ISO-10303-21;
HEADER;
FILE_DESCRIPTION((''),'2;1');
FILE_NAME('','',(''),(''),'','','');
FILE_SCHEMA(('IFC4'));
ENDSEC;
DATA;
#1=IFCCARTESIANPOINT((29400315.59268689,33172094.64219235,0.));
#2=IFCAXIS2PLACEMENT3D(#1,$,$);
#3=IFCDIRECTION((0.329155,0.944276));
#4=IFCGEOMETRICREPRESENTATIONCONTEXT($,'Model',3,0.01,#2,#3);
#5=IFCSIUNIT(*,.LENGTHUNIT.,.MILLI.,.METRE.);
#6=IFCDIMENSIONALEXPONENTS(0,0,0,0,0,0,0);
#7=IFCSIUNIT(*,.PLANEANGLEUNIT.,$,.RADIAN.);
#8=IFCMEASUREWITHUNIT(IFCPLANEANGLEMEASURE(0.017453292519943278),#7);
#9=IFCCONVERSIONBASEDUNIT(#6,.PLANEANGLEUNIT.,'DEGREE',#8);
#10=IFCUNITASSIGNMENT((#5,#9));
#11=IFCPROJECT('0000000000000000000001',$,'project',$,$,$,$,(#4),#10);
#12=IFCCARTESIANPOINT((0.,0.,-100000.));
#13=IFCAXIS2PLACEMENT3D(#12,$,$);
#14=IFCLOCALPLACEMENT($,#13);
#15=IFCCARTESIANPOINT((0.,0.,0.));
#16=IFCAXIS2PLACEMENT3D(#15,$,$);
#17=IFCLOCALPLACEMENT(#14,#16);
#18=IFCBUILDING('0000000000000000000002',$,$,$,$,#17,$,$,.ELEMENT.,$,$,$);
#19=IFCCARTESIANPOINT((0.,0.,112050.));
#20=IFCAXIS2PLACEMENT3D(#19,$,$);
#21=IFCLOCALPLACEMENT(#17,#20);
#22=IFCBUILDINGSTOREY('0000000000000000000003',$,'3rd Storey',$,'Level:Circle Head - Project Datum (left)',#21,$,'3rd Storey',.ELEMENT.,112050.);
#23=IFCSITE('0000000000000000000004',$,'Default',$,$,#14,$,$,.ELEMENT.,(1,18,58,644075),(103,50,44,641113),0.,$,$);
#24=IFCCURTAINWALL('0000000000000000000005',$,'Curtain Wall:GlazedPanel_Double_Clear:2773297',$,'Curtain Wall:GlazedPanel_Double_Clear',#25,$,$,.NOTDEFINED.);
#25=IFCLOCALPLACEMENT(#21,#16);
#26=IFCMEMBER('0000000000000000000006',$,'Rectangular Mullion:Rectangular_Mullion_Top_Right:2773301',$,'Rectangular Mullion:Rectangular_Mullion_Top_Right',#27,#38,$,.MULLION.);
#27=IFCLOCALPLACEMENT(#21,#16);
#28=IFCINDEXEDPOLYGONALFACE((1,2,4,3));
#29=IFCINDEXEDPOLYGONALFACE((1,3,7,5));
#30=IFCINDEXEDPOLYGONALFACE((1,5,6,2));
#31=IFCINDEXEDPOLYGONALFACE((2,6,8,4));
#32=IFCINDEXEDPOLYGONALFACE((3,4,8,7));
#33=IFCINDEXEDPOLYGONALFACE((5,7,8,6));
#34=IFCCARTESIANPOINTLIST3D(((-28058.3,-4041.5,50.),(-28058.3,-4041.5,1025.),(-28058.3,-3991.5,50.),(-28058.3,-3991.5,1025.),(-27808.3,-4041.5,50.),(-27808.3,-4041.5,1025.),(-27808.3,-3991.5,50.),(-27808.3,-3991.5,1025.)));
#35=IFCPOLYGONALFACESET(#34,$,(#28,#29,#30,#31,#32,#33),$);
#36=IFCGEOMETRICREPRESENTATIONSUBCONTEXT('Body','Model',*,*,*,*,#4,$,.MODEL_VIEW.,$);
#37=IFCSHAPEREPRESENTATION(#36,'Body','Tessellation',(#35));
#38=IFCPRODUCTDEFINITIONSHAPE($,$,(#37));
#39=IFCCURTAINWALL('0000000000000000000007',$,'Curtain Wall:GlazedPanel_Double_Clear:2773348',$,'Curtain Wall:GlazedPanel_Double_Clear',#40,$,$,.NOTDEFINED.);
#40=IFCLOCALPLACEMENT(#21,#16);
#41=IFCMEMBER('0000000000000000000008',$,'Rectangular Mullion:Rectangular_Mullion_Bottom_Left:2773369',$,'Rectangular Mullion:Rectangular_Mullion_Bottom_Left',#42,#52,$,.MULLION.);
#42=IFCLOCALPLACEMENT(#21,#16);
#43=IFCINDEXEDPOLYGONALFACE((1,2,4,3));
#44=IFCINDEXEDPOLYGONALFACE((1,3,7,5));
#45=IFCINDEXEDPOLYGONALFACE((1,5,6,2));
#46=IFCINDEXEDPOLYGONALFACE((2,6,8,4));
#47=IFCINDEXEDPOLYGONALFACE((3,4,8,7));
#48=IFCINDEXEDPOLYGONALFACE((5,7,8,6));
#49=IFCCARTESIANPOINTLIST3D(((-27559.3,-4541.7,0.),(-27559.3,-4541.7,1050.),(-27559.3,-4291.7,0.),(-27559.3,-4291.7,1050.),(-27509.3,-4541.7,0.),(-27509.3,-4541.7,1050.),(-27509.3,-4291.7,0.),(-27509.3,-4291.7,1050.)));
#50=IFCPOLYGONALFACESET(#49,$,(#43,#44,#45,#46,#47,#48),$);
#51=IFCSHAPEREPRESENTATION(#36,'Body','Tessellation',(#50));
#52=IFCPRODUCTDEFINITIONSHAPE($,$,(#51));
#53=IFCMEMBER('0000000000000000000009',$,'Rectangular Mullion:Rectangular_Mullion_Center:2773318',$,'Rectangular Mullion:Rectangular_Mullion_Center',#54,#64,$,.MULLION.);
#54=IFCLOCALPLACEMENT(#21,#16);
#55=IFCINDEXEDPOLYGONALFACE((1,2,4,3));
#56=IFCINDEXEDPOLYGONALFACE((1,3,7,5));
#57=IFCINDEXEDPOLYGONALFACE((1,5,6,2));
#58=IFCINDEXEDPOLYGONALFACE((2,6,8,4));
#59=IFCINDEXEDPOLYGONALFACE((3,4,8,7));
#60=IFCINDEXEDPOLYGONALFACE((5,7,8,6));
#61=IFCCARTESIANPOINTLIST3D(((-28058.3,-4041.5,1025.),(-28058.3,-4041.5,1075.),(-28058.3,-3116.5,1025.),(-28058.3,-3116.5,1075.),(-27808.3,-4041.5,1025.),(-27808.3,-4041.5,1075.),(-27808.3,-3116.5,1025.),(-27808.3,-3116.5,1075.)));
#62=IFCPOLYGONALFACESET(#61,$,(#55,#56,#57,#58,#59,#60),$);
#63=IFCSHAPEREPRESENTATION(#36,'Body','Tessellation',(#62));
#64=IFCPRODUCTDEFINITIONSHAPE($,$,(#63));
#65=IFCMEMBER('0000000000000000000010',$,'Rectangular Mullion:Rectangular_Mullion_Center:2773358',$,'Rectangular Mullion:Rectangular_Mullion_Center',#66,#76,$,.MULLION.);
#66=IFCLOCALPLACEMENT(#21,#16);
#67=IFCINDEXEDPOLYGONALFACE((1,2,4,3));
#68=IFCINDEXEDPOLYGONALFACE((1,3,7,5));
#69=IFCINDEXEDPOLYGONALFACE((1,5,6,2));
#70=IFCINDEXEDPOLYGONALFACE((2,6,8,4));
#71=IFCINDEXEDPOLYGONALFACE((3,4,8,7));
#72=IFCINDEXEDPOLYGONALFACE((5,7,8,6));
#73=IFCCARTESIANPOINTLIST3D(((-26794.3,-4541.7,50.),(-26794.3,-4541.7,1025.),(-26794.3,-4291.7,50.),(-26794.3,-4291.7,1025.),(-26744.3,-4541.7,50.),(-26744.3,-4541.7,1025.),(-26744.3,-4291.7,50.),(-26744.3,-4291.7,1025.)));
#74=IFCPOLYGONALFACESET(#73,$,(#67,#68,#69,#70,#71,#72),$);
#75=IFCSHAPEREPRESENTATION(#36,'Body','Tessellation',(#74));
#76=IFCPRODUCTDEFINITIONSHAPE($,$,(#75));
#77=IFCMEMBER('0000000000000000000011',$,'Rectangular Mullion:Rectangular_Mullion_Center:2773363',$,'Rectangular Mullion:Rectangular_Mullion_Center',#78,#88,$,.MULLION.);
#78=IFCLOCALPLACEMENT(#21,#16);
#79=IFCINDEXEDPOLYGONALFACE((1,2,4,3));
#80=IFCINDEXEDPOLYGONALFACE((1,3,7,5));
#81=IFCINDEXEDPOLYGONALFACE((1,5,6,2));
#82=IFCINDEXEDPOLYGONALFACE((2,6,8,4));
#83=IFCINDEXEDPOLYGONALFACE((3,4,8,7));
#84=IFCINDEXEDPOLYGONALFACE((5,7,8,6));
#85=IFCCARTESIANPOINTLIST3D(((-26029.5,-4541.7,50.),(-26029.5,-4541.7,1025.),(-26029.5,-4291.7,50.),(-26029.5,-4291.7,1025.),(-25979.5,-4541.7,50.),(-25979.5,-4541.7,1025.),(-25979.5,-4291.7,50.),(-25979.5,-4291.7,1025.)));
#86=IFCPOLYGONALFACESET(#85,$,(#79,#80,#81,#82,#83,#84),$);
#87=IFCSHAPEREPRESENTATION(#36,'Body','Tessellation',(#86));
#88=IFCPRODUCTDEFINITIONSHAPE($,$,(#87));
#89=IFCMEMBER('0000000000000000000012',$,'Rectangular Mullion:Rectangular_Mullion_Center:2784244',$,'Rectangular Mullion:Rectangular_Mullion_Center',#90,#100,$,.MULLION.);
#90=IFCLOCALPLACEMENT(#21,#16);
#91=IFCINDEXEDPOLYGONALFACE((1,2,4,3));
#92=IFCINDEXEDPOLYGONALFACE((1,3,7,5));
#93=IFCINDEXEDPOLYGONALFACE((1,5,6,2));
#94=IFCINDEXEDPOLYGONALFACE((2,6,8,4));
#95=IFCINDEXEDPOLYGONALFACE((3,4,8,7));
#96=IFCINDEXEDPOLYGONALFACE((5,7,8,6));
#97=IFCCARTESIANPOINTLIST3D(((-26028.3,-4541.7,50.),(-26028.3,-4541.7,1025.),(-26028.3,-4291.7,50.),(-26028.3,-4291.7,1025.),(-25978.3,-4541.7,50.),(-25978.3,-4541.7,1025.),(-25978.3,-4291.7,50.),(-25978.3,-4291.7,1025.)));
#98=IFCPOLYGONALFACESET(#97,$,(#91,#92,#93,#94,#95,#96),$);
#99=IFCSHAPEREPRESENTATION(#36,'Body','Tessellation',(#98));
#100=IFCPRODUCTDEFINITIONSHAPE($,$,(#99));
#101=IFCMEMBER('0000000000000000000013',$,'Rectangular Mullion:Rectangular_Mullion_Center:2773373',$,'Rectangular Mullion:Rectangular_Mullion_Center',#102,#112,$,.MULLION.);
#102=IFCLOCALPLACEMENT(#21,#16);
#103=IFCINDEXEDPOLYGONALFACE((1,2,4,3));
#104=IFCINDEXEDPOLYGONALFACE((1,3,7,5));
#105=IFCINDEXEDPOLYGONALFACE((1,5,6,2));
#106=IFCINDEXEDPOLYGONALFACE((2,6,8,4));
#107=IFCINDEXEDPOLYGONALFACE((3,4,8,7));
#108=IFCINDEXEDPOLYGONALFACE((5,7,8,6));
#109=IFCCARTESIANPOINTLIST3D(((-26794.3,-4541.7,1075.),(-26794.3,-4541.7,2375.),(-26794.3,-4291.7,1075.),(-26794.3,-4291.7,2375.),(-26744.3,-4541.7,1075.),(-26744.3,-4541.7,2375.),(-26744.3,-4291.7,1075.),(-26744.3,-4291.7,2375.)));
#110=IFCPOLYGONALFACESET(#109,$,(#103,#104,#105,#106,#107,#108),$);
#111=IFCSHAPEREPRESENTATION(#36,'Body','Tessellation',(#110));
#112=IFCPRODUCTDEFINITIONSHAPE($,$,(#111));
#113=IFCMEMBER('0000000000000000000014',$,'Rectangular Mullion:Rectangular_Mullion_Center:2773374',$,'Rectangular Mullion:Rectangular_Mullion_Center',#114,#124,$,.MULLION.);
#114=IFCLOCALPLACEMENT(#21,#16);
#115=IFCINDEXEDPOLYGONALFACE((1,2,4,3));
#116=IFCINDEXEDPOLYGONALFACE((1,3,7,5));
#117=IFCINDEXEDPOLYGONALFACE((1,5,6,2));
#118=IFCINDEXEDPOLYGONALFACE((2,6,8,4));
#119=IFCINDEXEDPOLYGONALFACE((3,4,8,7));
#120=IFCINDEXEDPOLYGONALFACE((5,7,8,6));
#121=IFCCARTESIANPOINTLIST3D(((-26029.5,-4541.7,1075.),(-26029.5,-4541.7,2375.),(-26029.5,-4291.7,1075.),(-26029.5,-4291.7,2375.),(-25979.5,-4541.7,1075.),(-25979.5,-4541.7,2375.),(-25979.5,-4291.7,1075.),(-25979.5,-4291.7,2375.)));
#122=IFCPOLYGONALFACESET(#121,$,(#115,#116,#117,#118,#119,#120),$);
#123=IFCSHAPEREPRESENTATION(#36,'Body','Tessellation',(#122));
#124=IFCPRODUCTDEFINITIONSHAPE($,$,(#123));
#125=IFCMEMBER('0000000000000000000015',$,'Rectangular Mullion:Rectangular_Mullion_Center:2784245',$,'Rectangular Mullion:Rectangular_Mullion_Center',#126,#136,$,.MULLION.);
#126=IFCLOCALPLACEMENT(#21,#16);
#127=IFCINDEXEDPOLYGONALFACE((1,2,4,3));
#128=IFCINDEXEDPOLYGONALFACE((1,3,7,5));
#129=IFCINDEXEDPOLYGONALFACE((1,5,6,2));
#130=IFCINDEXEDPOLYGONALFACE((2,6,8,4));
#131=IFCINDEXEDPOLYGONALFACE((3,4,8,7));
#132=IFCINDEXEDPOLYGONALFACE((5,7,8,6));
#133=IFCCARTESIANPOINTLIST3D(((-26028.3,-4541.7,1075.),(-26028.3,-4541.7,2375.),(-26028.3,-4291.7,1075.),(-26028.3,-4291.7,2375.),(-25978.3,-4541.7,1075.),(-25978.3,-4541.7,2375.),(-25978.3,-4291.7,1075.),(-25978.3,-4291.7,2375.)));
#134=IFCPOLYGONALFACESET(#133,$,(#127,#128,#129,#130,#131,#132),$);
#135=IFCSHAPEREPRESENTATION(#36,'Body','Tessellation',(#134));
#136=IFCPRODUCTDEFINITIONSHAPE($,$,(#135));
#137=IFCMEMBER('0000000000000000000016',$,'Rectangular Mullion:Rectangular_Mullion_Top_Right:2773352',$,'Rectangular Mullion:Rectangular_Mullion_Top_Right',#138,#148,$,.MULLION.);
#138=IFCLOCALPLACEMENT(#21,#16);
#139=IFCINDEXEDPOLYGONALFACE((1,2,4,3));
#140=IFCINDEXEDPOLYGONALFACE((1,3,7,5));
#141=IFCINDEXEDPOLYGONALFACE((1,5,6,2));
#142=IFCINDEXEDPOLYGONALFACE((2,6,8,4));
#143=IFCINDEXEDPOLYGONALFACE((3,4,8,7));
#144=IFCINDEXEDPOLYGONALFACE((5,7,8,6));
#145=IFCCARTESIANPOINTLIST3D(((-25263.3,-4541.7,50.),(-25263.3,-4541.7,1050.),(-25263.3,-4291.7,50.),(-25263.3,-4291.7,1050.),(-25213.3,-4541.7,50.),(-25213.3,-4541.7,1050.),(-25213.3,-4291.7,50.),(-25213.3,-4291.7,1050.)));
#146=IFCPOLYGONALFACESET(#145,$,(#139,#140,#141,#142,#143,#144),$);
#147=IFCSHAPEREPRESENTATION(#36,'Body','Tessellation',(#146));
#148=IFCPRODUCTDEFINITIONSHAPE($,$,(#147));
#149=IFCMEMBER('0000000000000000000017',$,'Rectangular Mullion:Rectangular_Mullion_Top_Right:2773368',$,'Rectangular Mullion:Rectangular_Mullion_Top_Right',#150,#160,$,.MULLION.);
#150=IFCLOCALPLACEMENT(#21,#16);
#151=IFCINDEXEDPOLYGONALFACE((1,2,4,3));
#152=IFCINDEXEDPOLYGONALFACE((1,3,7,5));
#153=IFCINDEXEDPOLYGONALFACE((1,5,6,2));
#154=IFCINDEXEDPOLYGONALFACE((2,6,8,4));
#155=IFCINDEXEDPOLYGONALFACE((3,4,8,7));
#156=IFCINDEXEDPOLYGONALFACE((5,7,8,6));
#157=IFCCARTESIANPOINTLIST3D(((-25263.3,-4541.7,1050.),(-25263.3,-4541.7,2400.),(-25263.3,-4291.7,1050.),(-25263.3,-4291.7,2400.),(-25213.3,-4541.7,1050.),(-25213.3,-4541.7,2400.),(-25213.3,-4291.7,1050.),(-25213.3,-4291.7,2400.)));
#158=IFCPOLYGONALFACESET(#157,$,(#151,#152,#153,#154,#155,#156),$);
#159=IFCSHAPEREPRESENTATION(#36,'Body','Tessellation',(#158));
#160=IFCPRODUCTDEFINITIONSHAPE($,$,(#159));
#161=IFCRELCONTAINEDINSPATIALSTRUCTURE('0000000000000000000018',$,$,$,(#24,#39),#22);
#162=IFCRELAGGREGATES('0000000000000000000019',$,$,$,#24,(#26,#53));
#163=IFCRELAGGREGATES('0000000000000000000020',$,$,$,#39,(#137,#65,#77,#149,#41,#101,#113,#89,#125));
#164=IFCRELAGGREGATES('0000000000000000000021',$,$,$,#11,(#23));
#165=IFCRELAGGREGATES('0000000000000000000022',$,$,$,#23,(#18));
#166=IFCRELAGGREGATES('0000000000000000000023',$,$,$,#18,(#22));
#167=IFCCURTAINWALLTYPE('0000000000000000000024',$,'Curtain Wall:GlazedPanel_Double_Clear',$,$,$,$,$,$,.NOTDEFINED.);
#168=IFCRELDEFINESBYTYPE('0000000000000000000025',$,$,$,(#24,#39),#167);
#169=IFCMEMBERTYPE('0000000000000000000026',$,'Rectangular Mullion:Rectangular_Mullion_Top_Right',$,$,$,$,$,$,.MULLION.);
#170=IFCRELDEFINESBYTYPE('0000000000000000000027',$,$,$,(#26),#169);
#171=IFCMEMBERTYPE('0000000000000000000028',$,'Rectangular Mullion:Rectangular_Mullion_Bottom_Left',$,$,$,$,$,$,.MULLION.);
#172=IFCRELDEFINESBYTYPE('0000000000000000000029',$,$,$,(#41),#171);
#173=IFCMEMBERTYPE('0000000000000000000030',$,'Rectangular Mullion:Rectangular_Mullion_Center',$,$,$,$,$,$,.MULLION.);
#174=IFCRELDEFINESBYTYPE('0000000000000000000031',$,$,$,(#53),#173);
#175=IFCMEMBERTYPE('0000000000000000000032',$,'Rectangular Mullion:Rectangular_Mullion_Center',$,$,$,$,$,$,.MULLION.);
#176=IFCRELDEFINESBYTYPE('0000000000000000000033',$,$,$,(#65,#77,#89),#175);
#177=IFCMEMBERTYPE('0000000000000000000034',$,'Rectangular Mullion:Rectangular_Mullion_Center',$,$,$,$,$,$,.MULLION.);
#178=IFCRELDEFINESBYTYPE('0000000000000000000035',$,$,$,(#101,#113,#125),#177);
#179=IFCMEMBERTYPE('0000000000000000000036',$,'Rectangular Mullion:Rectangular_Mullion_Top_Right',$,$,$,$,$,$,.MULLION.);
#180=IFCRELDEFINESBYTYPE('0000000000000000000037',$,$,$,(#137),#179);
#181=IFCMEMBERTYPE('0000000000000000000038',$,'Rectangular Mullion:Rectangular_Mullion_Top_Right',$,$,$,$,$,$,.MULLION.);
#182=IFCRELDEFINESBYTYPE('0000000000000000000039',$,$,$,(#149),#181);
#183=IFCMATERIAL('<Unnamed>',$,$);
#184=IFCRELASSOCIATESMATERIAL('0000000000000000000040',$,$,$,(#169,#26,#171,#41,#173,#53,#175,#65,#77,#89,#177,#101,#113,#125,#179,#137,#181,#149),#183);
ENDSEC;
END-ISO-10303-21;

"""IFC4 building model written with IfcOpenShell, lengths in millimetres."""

from ifc_helpers import new_model, entity, si_unit, converted_unit, direction, frame, origin, place, context, subcontext, project, spatial, indexed_curve, outline, extrude, source, transform, mapped, material, type_object, type_shapes, element, aggregate, save


model = new_model("IFC4")

# Units and contexts
model_context = context("Model", 3, precision=0.01, world=frame((29400315.59268689, 33172094.64219235, 0.0)), true_north=direction((0.329155, 0.944276)))
body_context = subcontext(model_context, "Body", "Model", "MODEL_VIEW")
ifc_project = project(units=[si_unit("LENGTHUNIT", "METRE", prefix="MILLI"), converted_unit("PLANEANGLEUNIT", "DEGREE", entity("IfcPlaneAngleMeasure", 0.017453292519943278), si_unit("PLANEANGLEUNIT", "RADIAN"), dimensions=[0, 0, 0, 0, 0, 0, 0])], contexts=[model_context])

# Site, building, storey
site_placement = place(None, frame((0.0, 0.0, -100000.0)))
site = spatial("IfcSite", under=ifc_project, at=site_placement, Name="Default", CompositionType="ELEMENT", RefLatitude=(1, 18, 58, 644075), RefLongitude=(103, 50, 44, 641113), RefElevation=0.0)
building_placement = place(site_placement, origin())
building = spatial("IfcBuilding", under=site, at=building_placement, CompositionType="ELEMENT")
storey_placement = place(building_placement, frame((0.0, 0.0, 112050.0)))
storey = spatial("IfcBuildingStorey", under=building, at=storey_placement, Name="3rd Storey", ObjectType="Level:Circle Head - Project Datum (left)", LongName="3rd Storey", CompositionType="ELEMENT", Elevation=112050.0)

# Curtain walls, members
curtain_wall_type = type_object("IfcCurtainWallType", Name="Curtain Wall:GlazedPanel_Double_Clear", PredefinedType="NOTDEFINED")
curtain_wall_1_placement = place(storey_placement, frame((0.0, 0.0, -112050.0)))
curtain_wall_1 = element("IfcCurtainWall", 1, at=curtain_wall_1_placement, inside=storey, type_object=curtain_wall_type, Name="Curtain Wall:GlazedPanel_Double_Clear:2773297", ObjectType="Curtain Wall:GlazedPanel_Double_Clear", PredefinedType="NOTDEFINED")
ifc_material_1 = material(Name="<Unnamed>")
member_type_1 = type_object("IfcMemberType", Name="Rectangular Mullion:Rectangular_Mullion_Top_Right", PredefinedType="MULLION", material=ifc_material_1)
shared_shape_1 = source(origin(), body_context, "Body", "SweptSolid", [
    extrude(outline(indexed_curve([(-25.0, -125.0), (25.0, -125.0), (25.0, 125.0), (-25.0, 125.0), (-25.0, -125.0)], self_intersect=False)), frame((-25.0, 0.0, -975.0), z_axis=(0.0, 0.0, 1.0), x_axis=(-1.0, 0.0, 0.0)), (0.0, 0.0, 1.0), 975.0),
])
type_shapes(member_type_1, [shared_shape_1])
member_1_placement = place(curtain_wall_1_placement, frame((-27933.3, -4041.5, 112100.0), z_axis=(0.0, 0.0, -1.0), x_axis=(0.0, -1.0, 0.0)))
member_1 = element("IfcMember", 2, at=member_1_placement, type_object=member_type_1, material=ifc_material_1, Name="Rectangular Mullion:Rectangular_Mullion_Top_Right:2773301", ObjectType="Rectangular Mullion:Rectangular_Mullion_Top_Right", PredefinedType="MULLION", context=body_context, shape_type="MappedRepresentation", body=[
    mapped(shared_shape_1, transform((0.0, 0.0, 0.0), scale=1.0)),
])
curtain_wall_2_placement = place(storey_placement, frame((0.0, 0.0, -112050.0)))
curtain_wall_2 = element("IfcCurtainWall", 3, at=curtain_wall_2_placement, inside=storey, type_object=curtain_wall_type, Name="Curtain Wall:GlazedPanel_Double_Clear:2773348", ObjectType="Curtain Wall:GlazedPanel_Double_Clear", PredefinedType="NOTDEFINED")
member_type_2 = type_object("IfcMemberType", Name="Rectangular Mullion:Rectangular_Mullion_Bottom_Left", PredefinedType="MULLION", material=ifc_material_1)
shared_shape_2 = source(origin(), body_context, "Body", "SweptSolid", [
    extrude(outline(indexed_curve([(-25.0, -125.0), (25.0, -125.0), (25.0, 125.0), (-25.0, 125.0), (-25.0, -125.0)], self_intersect=False)), frame((-25.0, 0.0, -1050.0), z_axis=(0.0, 0.0, 1.0), x_axis=(-1.0, 0.0, 0.0)), (0.0, 0.0, 1.0), 1050.0),
])
type_shapes(member_type_2, [shared_shape_2])
member_2_placement = place(curtain_wall_2_placement, frame((-27559.3, -4416.7, 113100.0), z_axis=(0.0, 0.0, 1.0), x_axis=(-1.0, 0.0, 0.0)))
member_2 = element("IfcMember", 4, at=member_2_placement, type_object=member_type_2, material=ifc_material_1, Name="Rectangular Mullion:Rectangular_Mullion_Bottom_Left:2773369", ObjectType="Rectangular Mullion:Rectangular_Mullion_Bottom_Left", PredefinedType="MULLION", context=body_context, shape_type="MappedRepresentation", body=[
    mapped(shared_shape_2, transform((0.0, 0.0, 0.0), scale=1.0)),
])

# Members
member_type_3 = type_object("IfcMemberType", Name="Rectangular Mullion:Rectangular_Mullion_Center", PredefinedType="MULLION", material=ifc_material_1)
shared_shape_3 = source(origin(), body_context, "Body", "SweptSolid", [
    extrude(outline(indexed_curve([(-25.0, -125.0), (25.0, -125.0), (25.0, 125.0), (-25.0, 125.0), (-25.0, -125.0)], self_intersect=False)), frame((0.0, 0.0, -925.0), z_axis=(0.0, 0.0, 1.0), x_axis=(-1.0, 0.0, 0.0)), (0.0, 0.0, 1.0), 925.0),
])
type_shapes(member_type_3, [shared_shape_3])
member_3_placement = place(curtain_wall_1_placement, frame((-27933.3, -4041.5, 113100.0), z_axis=(0.0, -1.0, 0.0), x_axis=(0.0, 0.0, 1.0)))
member_3 = element("IfcMember", 5, at=member_3_placement, type_object=member_type_3, material=ifc_material_1, Name="Rectangular Mullion:Rectangular_Mullion_Center:2773318", ObjectType="Rectangular Mullion:Rectangular_Mullion_Center", PredefinedType="MULLION", context=body_context, shape_type="MappedRepresentation", body=[
    mapped(shared_shape_3, transform((0.0, 0.0, 0.0), scale=1.0)),
])
member_type_4 = type_object("IfcMemberType", Name="Rectangular Mullion:Rectangular_Mullion_Center", PredefinedType="MULLION", material=ifc_material_1)
shared_shape_4 = source(origin(), body_context, "Body", "SweptSolid", [
    extrude(outline(indexed_curve([(-25.0, -125.0), (25.0, -125.0), (25.0, 125.0), (-25.0, 125.0), (-25.0, -125.0)], self_intersect=False)), frame((0.0, 0.0, -975.0), z_axis=(0.0, 0.0, 1.0), x_axis=(-1.0, 0.0, 0.0)), (0.0, 0.0, 1.0), 975.0),
])
type_shapes(member_type_4, [shared_shape_4])
member_4_placement = place(curtain_wall_2_placement, frame((-26769.3, -4416.7, 112100.0), z_axis=(0.0, 0.0, -1.0), x_axis=(1.0, 0.0, 0.0)))
member_4 = element("IfcMember", 6, at=member_4_placement, type_object=member_type_4, material=ifc_material_1, Name="Rectangular Mullion:Rectangular_Mullion_Center:2773358", ObjectType="Rectangular Mullion:Rectangular_Mullion_Center", PredefinedType="MULLION", context=body_context, shape_type="MappedRepresentation", body=[
    mapped(shared_shape_4, transform((0.0, 0.0, 0.0), scale=1.0)),
])
member_5_placement = place(curtain_wall_2_placement, frame((-26004.5, -4416.7, 112100.0), z_axis=(0.0, 0.0, -1.0), x_axis=(1.0, 0.0, 0.0)))
member_5 = element("IfcMember", 7, at=member_5_placement, type_object=member_type_4, material=ifc_material_1, Name="Rectangular Mullion:Rectangular_Mullion_Center:2773363", ObjectType="Rectangular Mullion:Rectangular_Mullion_Center", PredefinedType="MULLION", context=body_context, shape_type="MappedRepresentation", body=[
    mapped(shared_shape_4, transform((0.0, 0.0, 0.0), scale=1.0)),
])
member_6_placement = place(curtain_wall_2_placement, frame((-26003.3, -4416.7, 112100.0), z_axis=(0.0, 0.0, -1.0), x_axis=(1.0, 0.0, 0.0)))
member_6 = element("IfcMember", 8, at=member_6_placement, type_object=member_type_4, material=ifc_material_1, Name="Rectangular Mullion:Rectangular_Mullion_Center:2784244", ObjectType="Rectangular Mullion:Rectangular_Mullion_Center", PredefinedType="MULLION", context=body_context, shape_type="MappedRepresentation", body=[
    mapped(shared_shape_4, transform((0.0, 0.0, 0.0), scale=1.0)),
])
member_type_5 = type_object("IfcMemberType", Name="Rectangular Mullion:Rectangular_Mullion_Center", PredefinedType="MULLION", material=ifc_material_1)
shared_shape_5 = source(origin(), body_context, "Body", "SweptSolid", [
    extrude(outline(indexed_curve([(-25.0, -125.0), (25.0, -125.0), (25.0, 125.0), (-25.0, 125.0), (-25.0, -125.0)], self_intersect=False)), frame((0.0, 0.0, -1300.0), z_axis=(0.0, 0.0, 1.0), x_axis=(-1.0, 0.0, 0.0)), (0.0, 0.0, 1.0), 1300.0),
])
type_shapes(member_type_5, [shared_shape_5])
member_7_placement = place(curtain_wall_2_placement, frame((-26769.3, -4416.7, 113125.0), z_axis=(0.0, 0.0, -1.0), x_axis=(1.0, 0.0, 0.0)))
member_7 = element("IfcMember", 9, at=member_7_placement, type_object=member_type_5, material=ifc_material_1, Name="Rectangular Mullion:Rectangular_Mullion_Center:2773373", ObjectType="Rectangular Mullion:Rectangular_Mullion_Center", PredefinedType="MULLION", context=body_context, shape_type="MappedRepresentation", body=[
    mapped(shared_shape_5, transform((0.0, 0.0, 0.0), scale=1.0)),
])
member_8_placement = place(curtain_wall_2_placement, frame((-26004.5, -4416.7, 113125.0), z_axis=(0.0, 0.0, -1.0), x_axis=(1.0, 0.0, 0.0)))
member_8 = element("IfcMember", 10, at=member_8_placement, type_object=member_type_5, material=ifc_material_1, Name="Rectangular Mullion:Rectangular_Mullion_Center:2773374", ObjectType="Rectangular Mullion:Rectangular_Mullion_Center", PredefinedType="MULLION", context=body_context, shape_type="MappedRepresentation", body=[
    mapped(shared_shape_5, transform((0.0, 0.0, 0.0), scale=1.0)),
])
member_9_placement = place(curtain_wall_2_placement, frame((-26003.3, -4416.7, 113125.0), z_axis=(0.0, 0.0, -1.0), x_axis=(1.0, 0.0, 0.0)))
member_9 = element("IfcMember", 11, at=member_9_placement, type_object=member_type_5, material=ifc_material_1, Name="Rectangular Mullion:Rectangular_Mullion_Center:2784245", ObjectType="Rectangular Mullion:Rectangular_Mullion_Center", PredefinedType="MULLION", context=body_context, shape_type="MappedRepresentation", body=[
    mapped(shared_shape_5, transform((0.0, 0.0, 0.0), scale=1.0)),
])
member_type_6 = type_object("IfcMemberType", Name="Rectangular Mullion:Rectangular_Mullion_Top_Right", PredefinedType="MULLION", material=ifc_material_1)
shared_shape_6 = source(origin(), body_context, "Body", "SweptSolid", [
    extrude(outline(indexed_curve([(-25.0, -125.0), (25.0, -125.0), (25.0, 125.0), (-25.0, 125.0), (-25.0, -125.0)], self_intersect=False)), frame((-25.0, 0.0, -1000.0), z_axis=(0.0, 0.0, 1.0), x_axis=(-1.0, 0.0, 0.0)), (0.0, 0.0, 1.0), 1000.0),
])
type_shapes(member_type_6, [shared_shape_6])
member_10_placement = place(curtain_wall_2_placement, frame((-25213.3, -4416.7, 112100.0), z_axis=(0.0, 0.0, -1.0), x_axis=(1.0, 0.0, 0.0)))
member_10 = element("IfcMember", 12, at=member_10_placement, type_object=member_type_6, material=ifc_material_1, Name="Rectangular Mullion:Rectangular_Mullion_Top_Right:2773352", ObjectType="Rectangular Mullion:Rectangular_Mullion_Top_Right", PredefinedType="MULLION", context=body_context, shape_type="MappedRepresentation", body=[
    mapped(shared_shape_6, transform((0.0, 0.0, 0.0), scale=1.0)),
])
member_type_7 = type_object("IfcMemberType", Name="Rectangular Mullion:Rectangular_Mullion_Top_Right", PredefinedType="MULLION", material=ifc_material_1)
shared_shape_7 = source(origin(), body_context, "Body", "SweptSolid", [
    extrude(outline(indexed_curve([(-25.0, -125.0), (25.0, -125.0), (25.0, 125.0), (-25.0, 125.0), (-25.0, -125.0)], self_intersect=False)), frame((-25.0, 0.0, -1350.0), z_axis=(0.0, 0.0, 1.0), x_axis=(-1.0, 0.0, 0.0)), (0.0, 0.0, 1.0), 1350.0),
])
type_shapes(member_type_7, [shared_shape_7])
member_11_placement = place(curtain_wall_2_placement, frame((-25213.3, -4416.7, 113100.0), z_axis=(0.0, 0.0, -1.0), x_axis=(1.0, 0.0, 0.0)))
member_11 = element("IfcMember", 13, at=member_11_placement, type_object=member_type_7, material=ifc_material_1, Name="Rectangular Mullion:Rectangular_Mullion_Top_Right:2773368", ObjectType="Rectangular Mullion:Rectangular_Mullion_Top_Right", PredefinedType="MULLION", context=body_context, shape_type="MappedRepresentation", body=[
    mapped(shared_shape_7, transform((0.0, 0.0, 0.0), scale=1.0)),
])

aggregate(curtain_wall_1, [member_1, member_3])
aggregate(curtain_wall_2, [member_10, member_4, member_5, member_11, member_2, member_7, member_8, member_6, member_9])

save(model, "model.ifc")
